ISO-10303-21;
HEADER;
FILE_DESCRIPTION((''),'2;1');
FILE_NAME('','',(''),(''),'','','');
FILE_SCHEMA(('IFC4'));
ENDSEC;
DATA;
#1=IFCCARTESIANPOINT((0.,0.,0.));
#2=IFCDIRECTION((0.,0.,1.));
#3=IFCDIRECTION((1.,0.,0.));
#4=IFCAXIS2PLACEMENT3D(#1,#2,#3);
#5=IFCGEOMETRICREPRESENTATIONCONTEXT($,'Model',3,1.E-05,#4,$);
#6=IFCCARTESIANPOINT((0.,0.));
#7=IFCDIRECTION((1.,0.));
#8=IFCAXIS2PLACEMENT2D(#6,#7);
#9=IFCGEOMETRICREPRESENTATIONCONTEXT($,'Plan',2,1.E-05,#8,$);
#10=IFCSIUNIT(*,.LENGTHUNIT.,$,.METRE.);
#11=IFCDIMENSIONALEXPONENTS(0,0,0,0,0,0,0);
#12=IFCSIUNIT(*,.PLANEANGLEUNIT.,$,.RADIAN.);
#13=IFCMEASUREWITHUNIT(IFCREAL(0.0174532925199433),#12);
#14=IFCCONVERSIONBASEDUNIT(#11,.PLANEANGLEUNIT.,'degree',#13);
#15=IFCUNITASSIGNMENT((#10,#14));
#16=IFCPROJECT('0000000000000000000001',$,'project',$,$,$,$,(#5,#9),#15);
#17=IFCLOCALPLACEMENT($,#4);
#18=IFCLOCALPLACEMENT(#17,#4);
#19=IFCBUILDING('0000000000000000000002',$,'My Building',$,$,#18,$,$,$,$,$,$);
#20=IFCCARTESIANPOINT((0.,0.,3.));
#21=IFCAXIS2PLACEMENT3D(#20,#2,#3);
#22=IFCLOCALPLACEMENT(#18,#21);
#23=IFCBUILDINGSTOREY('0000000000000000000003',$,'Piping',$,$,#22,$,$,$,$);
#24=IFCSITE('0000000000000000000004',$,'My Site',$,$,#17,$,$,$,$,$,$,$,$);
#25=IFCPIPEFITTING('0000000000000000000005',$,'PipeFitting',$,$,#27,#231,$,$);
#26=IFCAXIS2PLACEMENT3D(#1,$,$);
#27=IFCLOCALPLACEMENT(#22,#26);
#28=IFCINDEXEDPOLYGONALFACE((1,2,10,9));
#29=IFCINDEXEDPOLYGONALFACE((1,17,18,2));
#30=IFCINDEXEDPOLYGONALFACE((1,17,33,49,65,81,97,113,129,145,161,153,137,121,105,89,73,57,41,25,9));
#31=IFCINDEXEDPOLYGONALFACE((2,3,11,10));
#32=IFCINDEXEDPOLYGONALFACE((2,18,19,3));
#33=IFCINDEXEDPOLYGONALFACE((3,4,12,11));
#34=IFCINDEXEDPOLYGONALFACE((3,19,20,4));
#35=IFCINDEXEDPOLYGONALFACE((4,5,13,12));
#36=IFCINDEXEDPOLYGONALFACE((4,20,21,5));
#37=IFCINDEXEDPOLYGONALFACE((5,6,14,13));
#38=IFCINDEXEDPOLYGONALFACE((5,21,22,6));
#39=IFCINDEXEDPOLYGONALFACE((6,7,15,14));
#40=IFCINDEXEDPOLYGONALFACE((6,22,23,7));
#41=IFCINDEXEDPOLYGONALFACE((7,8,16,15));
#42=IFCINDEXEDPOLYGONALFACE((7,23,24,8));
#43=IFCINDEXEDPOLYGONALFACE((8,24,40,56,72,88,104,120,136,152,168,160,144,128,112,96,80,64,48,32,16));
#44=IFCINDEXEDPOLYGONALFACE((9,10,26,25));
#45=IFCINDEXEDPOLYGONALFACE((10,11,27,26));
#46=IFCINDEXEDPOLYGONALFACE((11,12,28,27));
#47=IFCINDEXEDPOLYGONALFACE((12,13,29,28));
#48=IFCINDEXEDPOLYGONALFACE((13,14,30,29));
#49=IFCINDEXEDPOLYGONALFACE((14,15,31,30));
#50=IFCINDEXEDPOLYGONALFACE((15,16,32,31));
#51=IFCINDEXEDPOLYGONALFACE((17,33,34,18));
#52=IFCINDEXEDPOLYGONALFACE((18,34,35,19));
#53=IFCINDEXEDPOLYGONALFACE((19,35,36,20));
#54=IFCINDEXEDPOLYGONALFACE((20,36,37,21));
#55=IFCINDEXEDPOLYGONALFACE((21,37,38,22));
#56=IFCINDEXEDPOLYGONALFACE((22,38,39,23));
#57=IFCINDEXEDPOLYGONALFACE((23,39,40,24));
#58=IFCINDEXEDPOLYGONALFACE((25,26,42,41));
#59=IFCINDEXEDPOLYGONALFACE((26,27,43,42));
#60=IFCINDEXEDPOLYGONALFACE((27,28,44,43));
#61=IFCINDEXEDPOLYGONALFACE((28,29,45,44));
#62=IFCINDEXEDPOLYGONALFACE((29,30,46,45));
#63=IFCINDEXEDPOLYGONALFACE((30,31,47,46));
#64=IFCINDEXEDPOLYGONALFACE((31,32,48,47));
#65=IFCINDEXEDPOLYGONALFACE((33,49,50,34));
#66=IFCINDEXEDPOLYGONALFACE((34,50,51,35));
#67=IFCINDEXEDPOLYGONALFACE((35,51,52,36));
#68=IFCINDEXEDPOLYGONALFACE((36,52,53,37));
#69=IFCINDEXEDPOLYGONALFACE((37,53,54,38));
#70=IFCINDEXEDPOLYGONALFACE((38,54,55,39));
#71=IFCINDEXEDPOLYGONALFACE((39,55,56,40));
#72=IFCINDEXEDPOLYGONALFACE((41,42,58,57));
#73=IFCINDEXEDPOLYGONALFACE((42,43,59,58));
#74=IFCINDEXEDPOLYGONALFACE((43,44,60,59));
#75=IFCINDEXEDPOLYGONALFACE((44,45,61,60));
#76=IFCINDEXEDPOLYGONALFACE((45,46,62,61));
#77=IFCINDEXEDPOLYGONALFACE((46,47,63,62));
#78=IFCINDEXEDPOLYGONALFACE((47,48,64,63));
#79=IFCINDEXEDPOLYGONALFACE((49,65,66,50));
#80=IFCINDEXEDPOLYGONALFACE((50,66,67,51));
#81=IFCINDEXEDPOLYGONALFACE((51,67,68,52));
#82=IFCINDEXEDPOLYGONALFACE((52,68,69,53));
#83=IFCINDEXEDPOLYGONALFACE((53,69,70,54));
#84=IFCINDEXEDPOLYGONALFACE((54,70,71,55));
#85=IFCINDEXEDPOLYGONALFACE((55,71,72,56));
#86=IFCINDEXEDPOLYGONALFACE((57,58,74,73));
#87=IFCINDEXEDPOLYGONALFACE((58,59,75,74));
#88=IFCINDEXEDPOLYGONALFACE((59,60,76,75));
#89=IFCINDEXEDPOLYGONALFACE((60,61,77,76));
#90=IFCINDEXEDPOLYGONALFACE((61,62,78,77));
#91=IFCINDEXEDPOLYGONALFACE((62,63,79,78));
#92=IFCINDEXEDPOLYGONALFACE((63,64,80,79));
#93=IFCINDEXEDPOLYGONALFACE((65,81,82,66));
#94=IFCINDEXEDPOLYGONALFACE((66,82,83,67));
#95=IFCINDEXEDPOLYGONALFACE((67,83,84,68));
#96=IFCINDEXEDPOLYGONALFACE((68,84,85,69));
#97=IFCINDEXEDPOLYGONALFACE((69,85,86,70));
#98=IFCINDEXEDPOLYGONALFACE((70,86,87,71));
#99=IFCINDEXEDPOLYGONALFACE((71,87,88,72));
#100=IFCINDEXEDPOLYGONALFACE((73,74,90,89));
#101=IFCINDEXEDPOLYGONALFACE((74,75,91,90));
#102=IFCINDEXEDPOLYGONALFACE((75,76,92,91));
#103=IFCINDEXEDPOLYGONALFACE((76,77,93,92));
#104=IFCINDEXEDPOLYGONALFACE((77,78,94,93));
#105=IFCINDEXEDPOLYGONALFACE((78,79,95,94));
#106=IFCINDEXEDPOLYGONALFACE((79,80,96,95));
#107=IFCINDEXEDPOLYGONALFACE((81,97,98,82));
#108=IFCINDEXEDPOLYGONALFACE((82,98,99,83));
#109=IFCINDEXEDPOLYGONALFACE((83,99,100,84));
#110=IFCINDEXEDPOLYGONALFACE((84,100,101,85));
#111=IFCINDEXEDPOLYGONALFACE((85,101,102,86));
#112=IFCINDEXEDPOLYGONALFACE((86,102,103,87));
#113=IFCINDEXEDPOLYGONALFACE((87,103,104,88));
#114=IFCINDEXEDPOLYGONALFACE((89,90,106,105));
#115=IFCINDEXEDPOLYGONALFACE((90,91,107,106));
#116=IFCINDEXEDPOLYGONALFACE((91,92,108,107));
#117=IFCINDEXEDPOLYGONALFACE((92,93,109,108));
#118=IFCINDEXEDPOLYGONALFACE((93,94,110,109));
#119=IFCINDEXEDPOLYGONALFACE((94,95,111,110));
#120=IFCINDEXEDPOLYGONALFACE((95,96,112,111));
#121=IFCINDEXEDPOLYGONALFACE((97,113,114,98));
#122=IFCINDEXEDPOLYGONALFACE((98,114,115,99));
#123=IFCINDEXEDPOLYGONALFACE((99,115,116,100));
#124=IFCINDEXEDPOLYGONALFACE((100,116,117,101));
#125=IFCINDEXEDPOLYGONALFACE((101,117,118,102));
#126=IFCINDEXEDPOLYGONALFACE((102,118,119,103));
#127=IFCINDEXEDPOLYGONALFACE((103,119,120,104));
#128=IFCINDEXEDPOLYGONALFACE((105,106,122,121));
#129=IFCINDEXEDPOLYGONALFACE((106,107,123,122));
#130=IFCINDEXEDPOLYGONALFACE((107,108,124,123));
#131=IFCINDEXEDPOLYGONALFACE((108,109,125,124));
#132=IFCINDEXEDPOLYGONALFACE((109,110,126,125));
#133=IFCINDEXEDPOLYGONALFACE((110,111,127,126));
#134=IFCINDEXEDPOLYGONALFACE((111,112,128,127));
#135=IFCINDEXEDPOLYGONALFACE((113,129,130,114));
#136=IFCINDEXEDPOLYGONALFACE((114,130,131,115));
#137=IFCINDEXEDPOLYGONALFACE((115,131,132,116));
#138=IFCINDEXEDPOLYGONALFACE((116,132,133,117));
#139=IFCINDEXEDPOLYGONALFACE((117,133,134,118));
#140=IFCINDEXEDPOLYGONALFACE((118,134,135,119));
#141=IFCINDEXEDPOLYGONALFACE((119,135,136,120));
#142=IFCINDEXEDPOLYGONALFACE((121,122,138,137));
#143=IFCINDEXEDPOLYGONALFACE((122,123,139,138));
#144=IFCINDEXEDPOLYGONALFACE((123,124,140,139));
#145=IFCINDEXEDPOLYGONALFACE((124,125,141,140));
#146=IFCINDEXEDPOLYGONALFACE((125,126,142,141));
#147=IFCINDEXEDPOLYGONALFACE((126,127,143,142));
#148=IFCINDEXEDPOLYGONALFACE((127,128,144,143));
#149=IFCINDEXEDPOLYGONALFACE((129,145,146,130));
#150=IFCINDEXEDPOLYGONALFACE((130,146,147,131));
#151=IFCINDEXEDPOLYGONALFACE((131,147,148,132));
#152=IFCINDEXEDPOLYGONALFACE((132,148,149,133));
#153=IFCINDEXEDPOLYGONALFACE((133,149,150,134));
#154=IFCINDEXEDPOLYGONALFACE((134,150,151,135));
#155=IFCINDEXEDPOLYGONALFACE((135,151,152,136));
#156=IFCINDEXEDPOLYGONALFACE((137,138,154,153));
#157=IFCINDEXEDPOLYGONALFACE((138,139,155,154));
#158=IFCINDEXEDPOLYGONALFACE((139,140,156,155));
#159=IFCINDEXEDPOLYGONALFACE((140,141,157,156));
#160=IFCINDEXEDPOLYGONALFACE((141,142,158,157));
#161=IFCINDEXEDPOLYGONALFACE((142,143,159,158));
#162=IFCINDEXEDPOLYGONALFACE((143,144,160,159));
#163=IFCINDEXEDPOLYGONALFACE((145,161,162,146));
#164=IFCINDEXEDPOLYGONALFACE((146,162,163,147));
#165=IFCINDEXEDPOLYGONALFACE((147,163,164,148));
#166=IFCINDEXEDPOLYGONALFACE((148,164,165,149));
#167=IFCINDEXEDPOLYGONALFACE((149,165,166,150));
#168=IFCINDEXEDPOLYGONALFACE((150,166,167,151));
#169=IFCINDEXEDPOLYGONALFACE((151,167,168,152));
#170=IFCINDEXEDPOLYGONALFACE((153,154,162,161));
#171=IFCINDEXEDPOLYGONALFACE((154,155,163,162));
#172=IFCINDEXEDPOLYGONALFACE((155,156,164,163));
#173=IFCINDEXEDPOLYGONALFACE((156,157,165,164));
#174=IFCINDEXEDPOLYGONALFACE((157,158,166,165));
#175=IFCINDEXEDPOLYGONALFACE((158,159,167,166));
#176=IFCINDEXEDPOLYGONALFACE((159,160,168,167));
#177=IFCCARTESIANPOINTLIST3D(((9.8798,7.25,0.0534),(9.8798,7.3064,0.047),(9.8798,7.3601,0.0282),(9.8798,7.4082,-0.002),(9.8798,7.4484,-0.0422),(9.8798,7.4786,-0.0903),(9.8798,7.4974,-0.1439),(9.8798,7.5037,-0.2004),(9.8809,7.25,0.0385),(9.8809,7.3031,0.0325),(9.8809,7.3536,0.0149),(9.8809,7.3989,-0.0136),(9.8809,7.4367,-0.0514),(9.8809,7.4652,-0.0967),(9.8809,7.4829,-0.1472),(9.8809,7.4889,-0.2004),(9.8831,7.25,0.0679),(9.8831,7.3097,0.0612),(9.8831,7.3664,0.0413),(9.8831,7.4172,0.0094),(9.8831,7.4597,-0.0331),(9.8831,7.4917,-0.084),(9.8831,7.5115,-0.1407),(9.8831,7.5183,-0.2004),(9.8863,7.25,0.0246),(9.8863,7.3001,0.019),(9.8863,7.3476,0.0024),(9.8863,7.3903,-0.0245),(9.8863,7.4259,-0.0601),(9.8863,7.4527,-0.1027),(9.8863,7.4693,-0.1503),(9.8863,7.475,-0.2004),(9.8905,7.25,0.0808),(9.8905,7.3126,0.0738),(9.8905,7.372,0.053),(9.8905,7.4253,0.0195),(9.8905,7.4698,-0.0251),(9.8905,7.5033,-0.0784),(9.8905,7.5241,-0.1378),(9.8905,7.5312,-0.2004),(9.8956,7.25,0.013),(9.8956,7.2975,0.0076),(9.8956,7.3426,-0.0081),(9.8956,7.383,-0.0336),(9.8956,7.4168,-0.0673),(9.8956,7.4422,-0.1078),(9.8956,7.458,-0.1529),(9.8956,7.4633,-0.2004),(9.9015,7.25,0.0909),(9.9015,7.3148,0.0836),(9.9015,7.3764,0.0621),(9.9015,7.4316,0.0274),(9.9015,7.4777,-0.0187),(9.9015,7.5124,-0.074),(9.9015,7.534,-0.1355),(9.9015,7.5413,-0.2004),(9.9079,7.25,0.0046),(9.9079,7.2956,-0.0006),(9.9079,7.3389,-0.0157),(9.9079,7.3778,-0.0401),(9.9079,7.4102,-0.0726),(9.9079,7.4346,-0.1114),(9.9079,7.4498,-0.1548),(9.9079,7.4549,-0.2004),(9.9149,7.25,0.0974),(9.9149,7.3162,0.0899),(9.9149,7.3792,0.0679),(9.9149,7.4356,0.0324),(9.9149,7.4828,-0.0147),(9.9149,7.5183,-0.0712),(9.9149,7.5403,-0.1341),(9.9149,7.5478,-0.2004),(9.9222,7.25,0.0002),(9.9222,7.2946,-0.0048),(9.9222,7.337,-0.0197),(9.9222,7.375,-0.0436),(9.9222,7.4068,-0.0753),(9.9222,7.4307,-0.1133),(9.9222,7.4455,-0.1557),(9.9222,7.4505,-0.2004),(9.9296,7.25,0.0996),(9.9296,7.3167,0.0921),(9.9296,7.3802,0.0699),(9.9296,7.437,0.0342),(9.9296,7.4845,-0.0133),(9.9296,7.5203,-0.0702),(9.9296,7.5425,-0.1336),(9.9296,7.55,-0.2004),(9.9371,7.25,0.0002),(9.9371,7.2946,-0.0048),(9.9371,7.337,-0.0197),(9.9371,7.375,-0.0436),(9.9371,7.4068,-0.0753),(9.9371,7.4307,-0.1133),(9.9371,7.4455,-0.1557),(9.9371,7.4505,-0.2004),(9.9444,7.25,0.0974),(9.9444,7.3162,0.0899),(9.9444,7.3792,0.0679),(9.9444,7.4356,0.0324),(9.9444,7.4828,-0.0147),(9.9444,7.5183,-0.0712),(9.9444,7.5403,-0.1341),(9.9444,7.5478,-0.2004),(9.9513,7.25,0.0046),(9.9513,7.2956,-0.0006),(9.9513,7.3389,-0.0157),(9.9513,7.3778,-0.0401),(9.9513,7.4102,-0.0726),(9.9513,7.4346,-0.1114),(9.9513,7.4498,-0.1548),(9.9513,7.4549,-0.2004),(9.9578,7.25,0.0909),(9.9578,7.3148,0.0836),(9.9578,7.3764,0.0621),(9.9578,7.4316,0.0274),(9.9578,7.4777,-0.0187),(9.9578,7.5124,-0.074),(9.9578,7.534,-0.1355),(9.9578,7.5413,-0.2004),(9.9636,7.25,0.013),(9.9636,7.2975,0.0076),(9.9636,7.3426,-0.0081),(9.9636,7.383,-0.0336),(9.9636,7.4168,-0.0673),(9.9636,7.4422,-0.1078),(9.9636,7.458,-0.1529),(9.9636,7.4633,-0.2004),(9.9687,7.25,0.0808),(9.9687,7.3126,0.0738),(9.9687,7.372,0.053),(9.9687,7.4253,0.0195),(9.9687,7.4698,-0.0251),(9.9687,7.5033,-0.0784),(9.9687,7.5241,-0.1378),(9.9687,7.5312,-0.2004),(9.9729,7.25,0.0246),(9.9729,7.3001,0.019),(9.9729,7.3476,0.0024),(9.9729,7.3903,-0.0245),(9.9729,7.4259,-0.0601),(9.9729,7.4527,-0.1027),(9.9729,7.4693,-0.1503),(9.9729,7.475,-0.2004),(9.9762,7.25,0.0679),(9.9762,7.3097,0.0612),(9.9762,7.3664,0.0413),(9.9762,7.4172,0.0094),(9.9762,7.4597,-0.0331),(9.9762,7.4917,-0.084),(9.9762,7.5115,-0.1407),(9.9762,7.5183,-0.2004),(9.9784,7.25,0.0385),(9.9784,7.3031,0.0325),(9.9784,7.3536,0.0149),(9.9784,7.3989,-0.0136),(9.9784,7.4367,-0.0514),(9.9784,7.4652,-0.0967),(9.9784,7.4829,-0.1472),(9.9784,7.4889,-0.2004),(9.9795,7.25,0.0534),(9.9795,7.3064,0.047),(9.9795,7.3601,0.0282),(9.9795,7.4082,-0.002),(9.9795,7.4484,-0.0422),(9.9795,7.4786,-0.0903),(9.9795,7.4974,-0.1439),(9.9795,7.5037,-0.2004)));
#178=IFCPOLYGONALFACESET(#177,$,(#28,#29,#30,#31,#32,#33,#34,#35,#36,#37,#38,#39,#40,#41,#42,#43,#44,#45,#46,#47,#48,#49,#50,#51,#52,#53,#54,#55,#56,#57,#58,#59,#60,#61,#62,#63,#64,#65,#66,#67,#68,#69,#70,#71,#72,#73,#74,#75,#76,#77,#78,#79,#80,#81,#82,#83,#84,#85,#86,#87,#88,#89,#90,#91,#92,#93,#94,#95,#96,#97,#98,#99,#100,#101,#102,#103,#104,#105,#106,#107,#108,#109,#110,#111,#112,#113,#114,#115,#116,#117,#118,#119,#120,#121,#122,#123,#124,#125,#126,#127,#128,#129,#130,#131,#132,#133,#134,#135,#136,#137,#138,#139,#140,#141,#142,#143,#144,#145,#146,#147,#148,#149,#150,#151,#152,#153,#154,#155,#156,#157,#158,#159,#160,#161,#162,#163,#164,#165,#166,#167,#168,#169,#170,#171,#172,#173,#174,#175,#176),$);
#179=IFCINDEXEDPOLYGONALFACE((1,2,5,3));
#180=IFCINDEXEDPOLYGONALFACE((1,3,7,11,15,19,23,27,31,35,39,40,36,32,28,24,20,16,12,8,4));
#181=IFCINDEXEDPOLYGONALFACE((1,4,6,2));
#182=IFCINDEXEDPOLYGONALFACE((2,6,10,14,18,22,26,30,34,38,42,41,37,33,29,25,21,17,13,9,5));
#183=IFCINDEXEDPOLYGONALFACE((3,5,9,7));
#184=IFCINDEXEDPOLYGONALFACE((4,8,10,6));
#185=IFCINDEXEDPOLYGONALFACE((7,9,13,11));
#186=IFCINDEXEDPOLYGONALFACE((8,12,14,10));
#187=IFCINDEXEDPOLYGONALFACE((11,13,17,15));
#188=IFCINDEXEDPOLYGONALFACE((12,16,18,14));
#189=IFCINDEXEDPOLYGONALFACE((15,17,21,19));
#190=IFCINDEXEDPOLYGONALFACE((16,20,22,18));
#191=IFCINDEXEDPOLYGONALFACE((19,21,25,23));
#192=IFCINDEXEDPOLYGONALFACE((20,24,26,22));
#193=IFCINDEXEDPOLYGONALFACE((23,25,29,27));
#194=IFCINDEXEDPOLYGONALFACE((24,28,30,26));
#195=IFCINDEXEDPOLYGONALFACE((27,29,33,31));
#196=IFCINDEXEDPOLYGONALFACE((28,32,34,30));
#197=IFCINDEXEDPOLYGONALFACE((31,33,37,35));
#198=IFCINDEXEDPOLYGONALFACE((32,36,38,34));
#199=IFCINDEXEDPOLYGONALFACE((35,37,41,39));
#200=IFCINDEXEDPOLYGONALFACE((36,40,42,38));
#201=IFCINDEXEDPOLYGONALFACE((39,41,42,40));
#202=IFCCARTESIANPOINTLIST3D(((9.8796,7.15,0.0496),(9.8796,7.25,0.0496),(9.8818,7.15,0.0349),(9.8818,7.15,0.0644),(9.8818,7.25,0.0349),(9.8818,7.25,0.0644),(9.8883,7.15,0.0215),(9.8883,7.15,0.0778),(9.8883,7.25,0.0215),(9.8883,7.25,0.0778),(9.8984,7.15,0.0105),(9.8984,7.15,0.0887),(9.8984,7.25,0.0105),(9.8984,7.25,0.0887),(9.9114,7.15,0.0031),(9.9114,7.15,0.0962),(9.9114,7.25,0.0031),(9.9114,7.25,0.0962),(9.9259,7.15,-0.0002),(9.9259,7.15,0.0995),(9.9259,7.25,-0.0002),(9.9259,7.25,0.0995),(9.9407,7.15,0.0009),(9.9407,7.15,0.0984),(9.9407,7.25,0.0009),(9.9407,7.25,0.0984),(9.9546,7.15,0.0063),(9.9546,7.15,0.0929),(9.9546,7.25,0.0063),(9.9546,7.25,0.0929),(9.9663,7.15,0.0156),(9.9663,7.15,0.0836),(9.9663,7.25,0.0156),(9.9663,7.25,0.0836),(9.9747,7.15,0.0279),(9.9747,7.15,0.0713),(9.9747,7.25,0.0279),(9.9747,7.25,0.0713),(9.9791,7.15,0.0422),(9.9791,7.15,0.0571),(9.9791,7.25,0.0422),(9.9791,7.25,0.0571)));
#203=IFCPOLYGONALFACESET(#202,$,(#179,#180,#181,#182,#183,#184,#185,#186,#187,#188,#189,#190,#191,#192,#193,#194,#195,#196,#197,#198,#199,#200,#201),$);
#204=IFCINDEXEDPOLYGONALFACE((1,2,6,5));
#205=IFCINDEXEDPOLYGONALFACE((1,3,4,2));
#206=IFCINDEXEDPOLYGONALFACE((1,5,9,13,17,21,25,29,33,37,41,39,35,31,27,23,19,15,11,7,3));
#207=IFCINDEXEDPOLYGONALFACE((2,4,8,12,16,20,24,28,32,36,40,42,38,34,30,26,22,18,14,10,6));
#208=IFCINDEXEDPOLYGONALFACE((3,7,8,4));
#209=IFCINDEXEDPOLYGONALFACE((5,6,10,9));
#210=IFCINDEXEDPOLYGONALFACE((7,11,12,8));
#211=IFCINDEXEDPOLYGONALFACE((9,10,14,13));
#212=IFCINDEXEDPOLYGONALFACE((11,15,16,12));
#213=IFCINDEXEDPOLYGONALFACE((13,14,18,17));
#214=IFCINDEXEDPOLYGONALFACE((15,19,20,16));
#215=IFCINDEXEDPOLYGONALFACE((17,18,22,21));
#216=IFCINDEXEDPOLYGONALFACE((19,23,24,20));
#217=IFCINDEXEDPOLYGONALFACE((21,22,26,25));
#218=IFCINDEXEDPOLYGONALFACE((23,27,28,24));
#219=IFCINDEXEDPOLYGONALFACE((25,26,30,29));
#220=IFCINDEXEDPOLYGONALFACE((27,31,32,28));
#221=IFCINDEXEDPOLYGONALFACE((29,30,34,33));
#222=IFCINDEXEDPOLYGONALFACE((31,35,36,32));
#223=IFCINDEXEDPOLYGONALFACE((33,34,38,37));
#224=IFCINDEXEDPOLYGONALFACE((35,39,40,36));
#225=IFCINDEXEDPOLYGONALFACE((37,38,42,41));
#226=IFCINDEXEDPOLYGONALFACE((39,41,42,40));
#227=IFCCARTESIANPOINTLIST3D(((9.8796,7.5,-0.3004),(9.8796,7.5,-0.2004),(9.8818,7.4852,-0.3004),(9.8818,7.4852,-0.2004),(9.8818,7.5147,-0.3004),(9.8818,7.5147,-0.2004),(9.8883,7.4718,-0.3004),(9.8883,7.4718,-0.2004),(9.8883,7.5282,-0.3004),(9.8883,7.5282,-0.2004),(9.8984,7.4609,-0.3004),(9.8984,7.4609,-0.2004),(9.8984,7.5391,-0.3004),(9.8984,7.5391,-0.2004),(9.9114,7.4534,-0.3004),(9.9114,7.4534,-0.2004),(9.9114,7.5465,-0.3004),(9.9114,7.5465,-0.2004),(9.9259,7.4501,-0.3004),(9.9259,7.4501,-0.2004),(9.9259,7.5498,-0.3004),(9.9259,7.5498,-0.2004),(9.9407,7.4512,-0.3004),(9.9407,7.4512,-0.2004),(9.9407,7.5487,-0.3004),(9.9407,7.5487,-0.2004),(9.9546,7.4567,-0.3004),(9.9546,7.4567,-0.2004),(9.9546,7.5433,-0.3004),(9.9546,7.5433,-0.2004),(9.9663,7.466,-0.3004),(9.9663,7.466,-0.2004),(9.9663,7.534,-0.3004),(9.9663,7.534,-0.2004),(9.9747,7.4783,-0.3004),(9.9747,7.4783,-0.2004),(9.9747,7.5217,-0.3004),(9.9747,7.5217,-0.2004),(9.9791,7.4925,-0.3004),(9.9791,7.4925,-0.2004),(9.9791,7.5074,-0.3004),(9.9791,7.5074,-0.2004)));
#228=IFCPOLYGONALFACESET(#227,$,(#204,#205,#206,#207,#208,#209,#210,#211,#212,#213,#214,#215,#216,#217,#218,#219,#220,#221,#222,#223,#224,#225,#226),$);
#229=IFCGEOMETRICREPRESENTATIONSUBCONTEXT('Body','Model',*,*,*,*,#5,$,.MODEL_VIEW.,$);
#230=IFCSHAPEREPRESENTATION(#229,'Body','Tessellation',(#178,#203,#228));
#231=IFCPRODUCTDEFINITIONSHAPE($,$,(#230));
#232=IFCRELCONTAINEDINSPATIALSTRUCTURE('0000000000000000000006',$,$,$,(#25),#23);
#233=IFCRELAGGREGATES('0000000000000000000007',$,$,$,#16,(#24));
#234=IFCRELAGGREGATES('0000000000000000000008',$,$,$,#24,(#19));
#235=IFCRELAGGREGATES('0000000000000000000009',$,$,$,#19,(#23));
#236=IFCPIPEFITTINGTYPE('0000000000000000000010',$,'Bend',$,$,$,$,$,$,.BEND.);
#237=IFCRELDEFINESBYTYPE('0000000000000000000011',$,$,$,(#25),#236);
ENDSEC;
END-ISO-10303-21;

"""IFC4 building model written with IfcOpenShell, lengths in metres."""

from ifc_helpers import new_model, entity, si_unit, converted_unit, frame, origin_with_axes, origin_2d_with_axis, place, context, subcontext, project, spatial, circle, extrude, source, transform, mapped, type_object, type_shapes, element, save


model = new_model("IFC4")

# Units and contexts
model_context = context("Model", 3, precision=1e-05, world=origin_with_axes())
plan_context = context("Plan", 2, precision=1e-05, world=origin_2d_with_axis())
body_context = subcontext(model_context, "Body", "Model", "MODEL_VIEW")
ifc_project = project(units=[si_unit("LENGTHUNIT", "METRE"), converted_unit("PLANEANGLEUNIT", "degree", entity("IfcReal", 0.0174532925199433), si_unit("PLANEANGLEUNIT", "RADIAN"), dimensions=[0, 0, 0, 0, 0, 0, 0])], contexts=[model_context, plan_context])

# Site, building, storey
site_placement = place(None, origin_with_axes())
site = spatial("IfcSite", under=ifc_project, at=site_placement, Name="My Site")
building_placement = place(site_placement, origin_with_axes())
building = spatial("IfcBuilding", under=site, at=building_placement, Name="My Building")
storey_placement = place(building_placement, frame((0.0, 0.0, 3.0), z_axis=(0.0, 0.0, 1.0), x_axis=(1.0, 0.0, 0.0)))
storey = spatial("IfcBuildingStorey", under=building, at=storey_placement, Name="Piping")

# Pipe fitting
pipe_fitting_type_1 = type_object("IfcPipeFittingType", Name="Bend", PredefinedType="BEND")
shared_shape = source(origin_with_axes(), body_context, "Body", "SolidModel", [
    entity("IfcSweptDiskSolid", entity("IfcIndexedPolyCurve", entity("IfcCartesianPointList3D", [[0.0, 0.0, 0.1], [0.0, -0.0732, 0.2768], [0.0, -0.25, 0.35]]), [entity("IfcArcIndex", [1, 2, 3])]), 0.05),
    extrude(circle(Radius=0.05), origin_with_axes(), (0.0, 0.0, 1.0), 0.1),
    extrude(circle(Radius=0.05), frame((0.0, -0.25, 0.35), z_axis=(0.0, -1.0, 0.0), x_axis=(1.0, 0.0, 0.0)), (0.0, 0.0, 1.0), 0.1),
])
type_shapes(pipe_fitting_type_1, [shared_shape])
for number, where, z_axis, x_axis, name in (
    (1, (9.9296, 7.15, 0.0496), (0.0, 1.0, 0.0), (-1.0, 0.0, 0.0), "PipeFitting"),
):
    element("IfcPipeFitting", number, at=place(storey_placement, frame(where, z_axis=z_axis, x_axis=x_axis)), inside=storey, type_object=pipe_fitting_type_1, Name=name, context=body_context, shape_type="MappedRepresentation", body=[
        mapped(shared_shape, transform((0.0, 0.0, 0.0), x_axis=(1.0, 0.0, 0.0), y_axis=(0.0, 1.0, 0.0), z_axis=(0.0, 0.0, 1.0), scale=1.0)),
    ])

save(model, "model.ifc")
